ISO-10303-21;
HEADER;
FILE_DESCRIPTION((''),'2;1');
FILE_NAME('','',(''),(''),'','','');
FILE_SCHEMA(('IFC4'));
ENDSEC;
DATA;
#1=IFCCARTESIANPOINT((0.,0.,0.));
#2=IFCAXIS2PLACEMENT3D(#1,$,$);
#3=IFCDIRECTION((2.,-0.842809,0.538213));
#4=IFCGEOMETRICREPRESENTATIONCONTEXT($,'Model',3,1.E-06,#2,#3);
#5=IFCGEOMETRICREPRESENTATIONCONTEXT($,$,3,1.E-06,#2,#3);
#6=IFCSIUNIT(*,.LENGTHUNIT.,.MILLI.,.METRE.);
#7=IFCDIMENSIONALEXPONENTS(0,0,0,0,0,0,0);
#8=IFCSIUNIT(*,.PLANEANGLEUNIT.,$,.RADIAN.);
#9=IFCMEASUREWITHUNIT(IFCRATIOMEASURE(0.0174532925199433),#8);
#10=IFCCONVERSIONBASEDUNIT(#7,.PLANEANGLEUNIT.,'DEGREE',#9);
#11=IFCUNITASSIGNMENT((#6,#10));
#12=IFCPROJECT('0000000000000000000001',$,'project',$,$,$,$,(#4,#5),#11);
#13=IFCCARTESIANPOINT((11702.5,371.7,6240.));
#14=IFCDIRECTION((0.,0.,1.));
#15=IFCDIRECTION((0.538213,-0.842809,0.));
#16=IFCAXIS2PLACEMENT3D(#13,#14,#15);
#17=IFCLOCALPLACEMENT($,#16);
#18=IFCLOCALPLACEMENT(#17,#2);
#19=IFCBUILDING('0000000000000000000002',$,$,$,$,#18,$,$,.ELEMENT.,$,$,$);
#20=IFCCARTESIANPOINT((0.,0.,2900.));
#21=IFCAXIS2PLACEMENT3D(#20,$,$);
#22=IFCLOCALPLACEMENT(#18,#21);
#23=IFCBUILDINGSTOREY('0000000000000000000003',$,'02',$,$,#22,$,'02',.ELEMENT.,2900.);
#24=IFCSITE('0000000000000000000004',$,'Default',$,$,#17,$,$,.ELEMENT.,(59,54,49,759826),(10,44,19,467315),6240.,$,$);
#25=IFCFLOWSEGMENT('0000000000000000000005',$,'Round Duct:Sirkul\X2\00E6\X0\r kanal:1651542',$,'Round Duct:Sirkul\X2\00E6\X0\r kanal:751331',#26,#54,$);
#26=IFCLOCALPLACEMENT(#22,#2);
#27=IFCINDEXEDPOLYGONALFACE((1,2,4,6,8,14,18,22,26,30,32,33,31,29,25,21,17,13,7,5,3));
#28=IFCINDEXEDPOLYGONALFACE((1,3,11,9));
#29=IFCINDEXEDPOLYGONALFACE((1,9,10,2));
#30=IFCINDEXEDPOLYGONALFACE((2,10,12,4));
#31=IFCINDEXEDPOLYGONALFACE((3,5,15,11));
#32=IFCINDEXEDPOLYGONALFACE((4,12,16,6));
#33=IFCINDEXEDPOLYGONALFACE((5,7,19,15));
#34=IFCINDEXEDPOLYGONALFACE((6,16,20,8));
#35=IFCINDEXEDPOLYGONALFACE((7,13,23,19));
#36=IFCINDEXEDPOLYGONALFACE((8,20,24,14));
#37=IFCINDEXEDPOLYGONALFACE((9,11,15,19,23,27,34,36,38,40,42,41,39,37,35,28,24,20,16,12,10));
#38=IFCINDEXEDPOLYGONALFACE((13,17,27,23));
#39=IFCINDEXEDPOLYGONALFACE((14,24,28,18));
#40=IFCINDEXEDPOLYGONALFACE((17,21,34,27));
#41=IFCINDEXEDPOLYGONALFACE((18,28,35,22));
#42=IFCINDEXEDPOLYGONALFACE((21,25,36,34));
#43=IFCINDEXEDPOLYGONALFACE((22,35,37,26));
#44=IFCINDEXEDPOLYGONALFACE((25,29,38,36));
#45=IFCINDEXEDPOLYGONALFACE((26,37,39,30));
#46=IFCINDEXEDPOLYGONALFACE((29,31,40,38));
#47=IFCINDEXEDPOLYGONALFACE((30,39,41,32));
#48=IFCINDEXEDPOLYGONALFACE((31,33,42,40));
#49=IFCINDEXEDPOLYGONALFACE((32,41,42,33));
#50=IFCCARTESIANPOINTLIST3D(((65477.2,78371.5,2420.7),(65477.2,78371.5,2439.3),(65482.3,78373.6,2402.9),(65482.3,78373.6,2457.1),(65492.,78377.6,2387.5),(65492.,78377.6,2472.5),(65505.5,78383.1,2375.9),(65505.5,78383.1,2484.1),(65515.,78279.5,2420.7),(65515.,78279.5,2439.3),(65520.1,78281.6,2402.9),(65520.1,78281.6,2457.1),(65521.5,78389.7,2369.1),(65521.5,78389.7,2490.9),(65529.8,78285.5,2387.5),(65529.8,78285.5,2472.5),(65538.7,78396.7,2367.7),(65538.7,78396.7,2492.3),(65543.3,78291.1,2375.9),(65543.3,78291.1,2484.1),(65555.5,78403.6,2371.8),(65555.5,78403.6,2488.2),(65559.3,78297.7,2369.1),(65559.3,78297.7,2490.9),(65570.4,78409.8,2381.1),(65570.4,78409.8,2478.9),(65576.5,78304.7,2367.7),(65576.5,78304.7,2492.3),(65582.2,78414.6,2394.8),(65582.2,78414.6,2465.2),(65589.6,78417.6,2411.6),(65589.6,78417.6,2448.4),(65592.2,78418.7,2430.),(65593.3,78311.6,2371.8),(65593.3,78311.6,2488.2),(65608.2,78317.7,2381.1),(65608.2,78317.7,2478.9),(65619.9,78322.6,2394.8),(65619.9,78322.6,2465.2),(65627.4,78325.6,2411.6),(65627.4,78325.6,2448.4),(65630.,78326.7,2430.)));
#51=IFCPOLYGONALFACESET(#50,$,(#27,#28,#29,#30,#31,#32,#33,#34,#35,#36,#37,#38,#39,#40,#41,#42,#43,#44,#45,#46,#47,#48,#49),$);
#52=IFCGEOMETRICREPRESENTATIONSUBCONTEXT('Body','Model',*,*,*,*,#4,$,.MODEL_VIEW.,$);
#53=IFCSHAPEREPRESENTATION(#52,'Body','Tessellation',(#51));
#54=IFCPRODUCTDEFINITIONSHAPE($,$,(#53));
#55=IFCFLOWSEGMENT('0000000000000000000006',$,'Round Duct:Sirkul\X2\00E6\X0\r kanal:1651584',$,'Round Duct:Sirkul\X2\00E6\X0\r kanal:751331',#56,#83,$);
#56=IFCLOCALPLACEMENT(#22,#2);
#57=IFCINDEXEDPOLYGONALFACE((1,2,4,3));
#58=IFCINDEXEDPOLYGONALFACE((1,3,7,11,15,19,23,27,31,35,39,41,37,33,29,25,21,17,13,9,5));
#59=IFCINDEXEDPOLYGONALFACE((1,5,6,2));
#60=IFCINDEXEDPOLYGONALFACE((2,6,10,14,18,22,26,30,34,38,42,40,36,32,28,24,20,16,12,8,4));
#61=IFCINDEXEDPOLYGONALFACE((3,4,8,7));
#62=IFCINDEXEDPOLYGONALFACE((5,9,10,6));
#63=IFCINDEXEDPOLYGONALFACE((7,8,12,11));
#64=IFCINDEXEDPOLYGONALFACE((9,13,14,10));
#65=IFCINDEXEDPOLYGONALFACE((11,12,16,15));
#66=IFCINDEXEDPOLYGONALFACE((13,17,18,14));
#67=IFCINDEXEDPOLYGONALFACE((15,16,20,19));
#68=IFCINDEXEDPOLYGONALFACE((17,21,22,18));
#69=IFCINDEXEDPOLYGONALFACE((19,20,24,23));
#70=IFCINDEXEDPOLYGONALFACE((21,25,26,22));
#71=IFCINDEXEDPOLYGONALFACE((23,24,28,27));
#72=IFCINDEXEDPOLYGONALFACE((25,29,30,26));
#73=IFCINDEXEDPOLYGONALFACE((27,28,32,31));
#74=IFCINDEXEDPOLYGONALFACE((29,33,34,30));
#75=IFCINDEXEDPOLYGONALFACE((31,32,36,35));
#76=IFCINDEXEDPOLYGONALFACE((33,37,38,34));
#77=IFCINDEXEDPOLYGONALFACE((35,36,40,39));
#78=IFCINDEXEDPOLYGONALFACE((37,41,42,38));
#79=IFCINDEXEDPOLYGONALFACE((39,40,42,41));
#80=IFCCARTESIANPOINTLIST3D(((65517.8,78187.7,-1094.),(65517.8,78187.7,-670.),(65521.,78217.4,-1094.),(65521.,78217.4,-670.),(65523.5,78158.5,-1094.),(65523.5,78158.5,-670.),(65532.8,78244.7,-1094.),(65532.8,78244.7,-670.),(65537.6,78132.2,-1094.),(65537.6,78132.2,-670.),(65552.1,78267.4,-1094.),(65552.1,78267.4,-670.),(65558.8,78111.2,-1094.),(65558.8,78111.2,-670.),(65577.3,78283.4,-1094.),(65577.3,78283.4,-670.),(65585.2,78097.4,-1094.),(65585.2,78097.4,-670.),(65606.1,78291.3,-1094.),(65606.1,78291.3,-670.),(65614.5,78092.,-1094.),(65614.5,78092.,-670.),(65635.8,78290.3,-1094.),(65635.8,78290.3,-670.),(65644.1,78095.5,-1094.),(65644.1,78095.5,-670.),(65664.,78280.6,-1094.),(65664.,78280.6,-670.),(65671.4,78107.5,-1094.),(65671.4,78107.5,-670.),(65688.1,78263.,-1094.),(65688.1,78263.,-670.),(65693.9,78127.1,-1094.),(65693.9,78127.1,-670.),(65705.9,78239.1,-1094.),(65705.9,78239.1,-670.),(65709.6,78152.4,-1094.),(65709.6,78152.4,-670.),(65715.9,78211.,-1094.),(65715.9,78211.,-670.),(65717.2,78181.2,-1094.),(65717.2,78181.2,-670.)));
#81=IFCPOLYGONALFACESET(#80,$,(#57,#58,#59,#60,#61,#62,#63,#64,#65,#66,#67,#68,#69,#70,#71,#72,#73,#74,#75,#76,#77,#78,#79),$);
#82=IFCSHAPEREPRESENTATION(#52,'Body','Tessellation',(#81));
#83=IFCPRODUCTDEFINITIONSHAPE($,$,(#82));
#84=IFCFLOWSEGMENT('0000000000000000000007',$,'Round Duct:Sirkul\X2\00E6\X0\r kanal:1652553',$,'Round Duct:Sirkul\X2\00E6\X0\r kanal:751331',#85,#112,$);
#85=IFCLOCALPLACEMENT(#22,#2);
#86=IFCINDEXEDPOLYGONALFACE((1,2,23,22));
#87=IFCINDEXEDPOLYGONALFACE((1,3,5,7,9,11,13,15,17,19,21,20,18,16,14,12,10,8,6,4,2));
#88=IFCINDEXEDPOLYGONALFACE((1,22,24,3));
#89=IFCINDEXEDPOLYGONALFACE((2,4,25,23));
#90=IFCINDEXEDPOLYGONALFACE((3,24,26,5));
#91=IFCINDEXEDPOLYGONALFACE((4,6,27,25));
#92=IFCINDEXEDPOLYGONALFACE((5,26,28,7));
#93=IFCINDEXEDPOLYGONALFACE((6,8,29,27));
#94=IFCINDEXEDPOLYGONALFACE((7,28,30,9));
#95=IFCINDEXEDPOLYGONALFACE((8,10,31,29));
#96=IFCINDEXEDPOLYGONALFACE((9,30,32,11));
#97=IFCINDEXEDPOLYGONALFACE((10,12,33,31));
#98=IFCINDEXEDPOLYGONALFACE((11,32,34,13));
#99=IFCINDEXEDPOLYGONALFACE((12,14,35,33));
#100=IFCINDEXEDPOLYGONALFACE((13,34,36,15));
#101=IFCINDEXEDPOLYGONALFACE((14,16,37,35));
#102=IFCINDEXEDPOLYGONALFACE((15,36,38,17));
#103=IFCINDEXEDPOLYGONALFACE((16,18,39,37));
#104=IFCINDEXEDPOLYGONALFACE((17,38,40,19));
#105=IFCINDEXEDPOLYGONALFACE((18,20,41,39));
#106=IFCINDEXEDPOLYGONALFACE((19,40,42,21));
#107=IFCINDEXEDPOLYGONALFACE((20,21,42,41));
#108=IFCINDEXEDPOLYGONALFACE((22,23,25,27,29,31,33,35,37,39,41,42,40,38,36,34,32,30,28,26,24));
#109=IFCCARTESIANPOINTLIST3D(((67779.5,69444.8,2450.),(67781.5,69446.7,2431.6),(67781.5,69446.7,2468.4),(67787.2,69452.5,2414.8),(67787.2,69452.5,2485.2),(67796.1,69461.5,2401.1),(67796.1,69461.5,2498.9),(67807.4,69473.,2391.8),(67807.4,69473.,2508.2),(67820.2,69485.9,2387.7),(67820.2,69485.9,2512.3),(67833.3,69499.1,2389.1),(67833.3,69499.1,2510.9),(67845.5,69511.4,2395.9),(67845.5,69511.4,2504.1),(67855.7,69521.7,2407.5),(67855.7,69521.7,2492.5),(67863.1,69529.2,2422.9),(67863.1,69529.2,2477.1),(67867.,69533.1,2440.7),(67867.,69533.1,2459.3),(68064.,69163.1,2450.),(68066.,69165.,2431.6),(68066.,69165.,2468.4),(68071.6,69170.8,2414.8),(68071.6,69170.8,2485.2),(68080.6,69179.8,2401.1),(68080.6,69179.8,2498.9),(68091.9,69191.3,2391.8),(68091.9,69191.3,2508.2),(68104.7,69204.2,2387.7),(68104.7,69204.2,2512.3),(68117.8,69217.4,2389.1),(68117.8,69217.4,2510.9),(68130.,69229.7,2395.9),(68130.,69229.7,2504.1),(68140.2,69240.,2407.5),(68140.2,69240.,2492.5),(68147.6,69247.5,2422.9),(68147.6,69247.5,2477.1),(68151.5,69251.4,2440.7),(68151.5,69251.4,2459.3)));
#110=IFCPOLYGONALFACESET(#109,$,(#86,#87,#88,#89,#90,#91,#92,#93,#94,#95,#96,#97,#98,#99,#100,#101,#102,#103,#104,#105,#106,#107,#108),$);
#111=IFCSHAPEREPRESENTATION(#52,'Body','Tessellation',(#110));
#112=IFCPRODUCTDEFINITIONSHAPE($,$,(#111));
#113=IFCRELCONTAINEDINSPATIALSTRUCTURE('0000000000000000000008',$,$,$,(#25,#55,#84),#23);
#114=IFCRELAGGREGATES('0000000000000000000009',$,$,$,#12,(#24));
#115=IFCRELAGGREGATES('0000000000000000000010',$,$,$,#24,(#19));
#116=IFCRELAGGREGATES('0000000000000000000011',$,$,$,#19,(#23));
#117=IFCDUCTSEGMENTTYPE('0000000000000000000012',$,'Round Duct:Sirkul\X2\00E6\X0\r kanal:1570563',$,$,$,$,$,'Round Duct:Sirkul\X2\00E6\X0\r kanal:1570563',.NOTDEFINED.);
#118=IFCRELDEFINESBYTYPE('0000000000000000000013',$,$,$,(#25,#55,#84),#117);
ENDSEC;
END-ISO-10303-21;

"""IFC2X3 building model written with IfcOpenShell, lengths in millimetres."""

from ifc_helpers import new_model, entity, si_unit, converted_unit, direction, frame, origin, origin_2d_with_axis, place, context, subcontext, project, spatial, circle, extrude, type_object, element, save


model = new_model("IFC2X3")

# Units and contexts
model_context = context("Model", 3, precision=1e-06, world=origin(), true_north=direction((2.0, -0.842809, 0.538213)))
context_of_model = context(None, 3, precision=1e-06, world=origin(), true_north=direction((2.0, -0.842809, 0.538213)))
body_context = subcontext(model_context, "Body", "Model", "MODEL_VIEW")
ifc_project = project(units=[si_unit("LENGTHUNIT", "METRE", prefix="MILLI"), converted_unit("PLANEANGLEUNIT", "DEGREE", entity("IfcRatioMeasure", 0.0174532925199433), si_unit("PLANEANGLEUNIT", "RADIAN"), dimensions=[0, 0, 0, 0, 0, 0, 0])], contexts=[model_context, context_of_model])

# Site, building, storey
site_placement = place(None, frame((11702.5, 371.7, 6240.0), z_axis=(0.0, 0.0, 1.0), x_axis=(0.538213, -0.842809, 0.0)))
site = spatial("IfcSite", under=ifc_project, at=site_placement, Name="Default", CompositionType="ELEMENT", RefLatitude=(59, 54, 49, 759826), RefLongitude=(10, 44, 19, 467315), RefElevation=6240.0)
building_placement = place(site_placement, origin())
building = spatial("IfcBuilding", under=site, at=building_placement, CompositionType="ELEMENT")
storey_placement = place(building_placement, frame((0.0, 0.0, 2900.0)))
storey = spatial("IfcBuildingStorey", under=building, at=storey_placement, Name="02", LongName="02", CompositionType="ELEMENT", Elevation=2900.0)

# Flow segments
duct_segment_type = type_object("IfcDuctSegmentType", Name="Round Duct:Sirkulær kanal:1570563", ElementType="Round Duct:Sirkulær kanal:1570563", PredefinedType="NOTDEFINED")
flow_segment_1_placement = place(storey_placement, origin())
element("IfcFlowSegment", 1, at=flow_segment_1_placement, inside=storey, type_object=duct_segment_type, Name="Round Duct:Sirkulær kanal:1651542", ObjectType="Round Duct:Sirkulær kanal:751331", context=body_context, shape_type="SweptSolid", body=[
    extrude(circle(Radius=62.5, at=origin_2d_with_axis()), frame((65534.4, 78395.0, 2430.0), z_axis=(0.379807, -0.925066, 0.0), x_axis=(0.925066, 0.379807, 0.0)), (0.0, 0.0, 1.0), 99.5),
])
flow_segment_2_placement = place(storey_placement, origin())
element("IfcFlowSegment", 2, at=flow_segment_2_placement, inside=storey, type_object=duct_segment_type, Name="Round Duct:Sirkulær kanal:1651584", ObjectType="Round Duct:Sirkulær kanal:751331", context=body_context, shape_type="SweptSolid", body=[
    extrude(circle(Radius=100.0, at=origin_2d_with_axis()), frame((65617.7, 78191.9, -1094.0), z_axis=(0.0, 0.0, 1.0), x_axis=(0.703643, 0.710554, 0.0)), (0.0, 0.0, 1.0), 424.0),
])
flow_segment_3_placement = place(storey_placement, origin())
element("IfcFlowSegment", 3, at=flow_segment_3_placement, inside=storey, type_object=duct_segment_type, Name="Round Duct:Sirkulær kanal:1652553", ObjectType="Round Duct:Sirkulær kanal:751331", context=body_context, shape_type="SweptSolid", body=[
    extrude(circle(Radius=62.5, at=origin_2d_with_axis()), frame((68108.0, 69207.5, 2450.0), z_axis=(-0.710554, 0.703643, 0.0), x_axis=(-0.703643, -0.710554, 0.0)), (0.0, 0.0, 1.0), 400.4),
])

save(model, "model.ifc")
